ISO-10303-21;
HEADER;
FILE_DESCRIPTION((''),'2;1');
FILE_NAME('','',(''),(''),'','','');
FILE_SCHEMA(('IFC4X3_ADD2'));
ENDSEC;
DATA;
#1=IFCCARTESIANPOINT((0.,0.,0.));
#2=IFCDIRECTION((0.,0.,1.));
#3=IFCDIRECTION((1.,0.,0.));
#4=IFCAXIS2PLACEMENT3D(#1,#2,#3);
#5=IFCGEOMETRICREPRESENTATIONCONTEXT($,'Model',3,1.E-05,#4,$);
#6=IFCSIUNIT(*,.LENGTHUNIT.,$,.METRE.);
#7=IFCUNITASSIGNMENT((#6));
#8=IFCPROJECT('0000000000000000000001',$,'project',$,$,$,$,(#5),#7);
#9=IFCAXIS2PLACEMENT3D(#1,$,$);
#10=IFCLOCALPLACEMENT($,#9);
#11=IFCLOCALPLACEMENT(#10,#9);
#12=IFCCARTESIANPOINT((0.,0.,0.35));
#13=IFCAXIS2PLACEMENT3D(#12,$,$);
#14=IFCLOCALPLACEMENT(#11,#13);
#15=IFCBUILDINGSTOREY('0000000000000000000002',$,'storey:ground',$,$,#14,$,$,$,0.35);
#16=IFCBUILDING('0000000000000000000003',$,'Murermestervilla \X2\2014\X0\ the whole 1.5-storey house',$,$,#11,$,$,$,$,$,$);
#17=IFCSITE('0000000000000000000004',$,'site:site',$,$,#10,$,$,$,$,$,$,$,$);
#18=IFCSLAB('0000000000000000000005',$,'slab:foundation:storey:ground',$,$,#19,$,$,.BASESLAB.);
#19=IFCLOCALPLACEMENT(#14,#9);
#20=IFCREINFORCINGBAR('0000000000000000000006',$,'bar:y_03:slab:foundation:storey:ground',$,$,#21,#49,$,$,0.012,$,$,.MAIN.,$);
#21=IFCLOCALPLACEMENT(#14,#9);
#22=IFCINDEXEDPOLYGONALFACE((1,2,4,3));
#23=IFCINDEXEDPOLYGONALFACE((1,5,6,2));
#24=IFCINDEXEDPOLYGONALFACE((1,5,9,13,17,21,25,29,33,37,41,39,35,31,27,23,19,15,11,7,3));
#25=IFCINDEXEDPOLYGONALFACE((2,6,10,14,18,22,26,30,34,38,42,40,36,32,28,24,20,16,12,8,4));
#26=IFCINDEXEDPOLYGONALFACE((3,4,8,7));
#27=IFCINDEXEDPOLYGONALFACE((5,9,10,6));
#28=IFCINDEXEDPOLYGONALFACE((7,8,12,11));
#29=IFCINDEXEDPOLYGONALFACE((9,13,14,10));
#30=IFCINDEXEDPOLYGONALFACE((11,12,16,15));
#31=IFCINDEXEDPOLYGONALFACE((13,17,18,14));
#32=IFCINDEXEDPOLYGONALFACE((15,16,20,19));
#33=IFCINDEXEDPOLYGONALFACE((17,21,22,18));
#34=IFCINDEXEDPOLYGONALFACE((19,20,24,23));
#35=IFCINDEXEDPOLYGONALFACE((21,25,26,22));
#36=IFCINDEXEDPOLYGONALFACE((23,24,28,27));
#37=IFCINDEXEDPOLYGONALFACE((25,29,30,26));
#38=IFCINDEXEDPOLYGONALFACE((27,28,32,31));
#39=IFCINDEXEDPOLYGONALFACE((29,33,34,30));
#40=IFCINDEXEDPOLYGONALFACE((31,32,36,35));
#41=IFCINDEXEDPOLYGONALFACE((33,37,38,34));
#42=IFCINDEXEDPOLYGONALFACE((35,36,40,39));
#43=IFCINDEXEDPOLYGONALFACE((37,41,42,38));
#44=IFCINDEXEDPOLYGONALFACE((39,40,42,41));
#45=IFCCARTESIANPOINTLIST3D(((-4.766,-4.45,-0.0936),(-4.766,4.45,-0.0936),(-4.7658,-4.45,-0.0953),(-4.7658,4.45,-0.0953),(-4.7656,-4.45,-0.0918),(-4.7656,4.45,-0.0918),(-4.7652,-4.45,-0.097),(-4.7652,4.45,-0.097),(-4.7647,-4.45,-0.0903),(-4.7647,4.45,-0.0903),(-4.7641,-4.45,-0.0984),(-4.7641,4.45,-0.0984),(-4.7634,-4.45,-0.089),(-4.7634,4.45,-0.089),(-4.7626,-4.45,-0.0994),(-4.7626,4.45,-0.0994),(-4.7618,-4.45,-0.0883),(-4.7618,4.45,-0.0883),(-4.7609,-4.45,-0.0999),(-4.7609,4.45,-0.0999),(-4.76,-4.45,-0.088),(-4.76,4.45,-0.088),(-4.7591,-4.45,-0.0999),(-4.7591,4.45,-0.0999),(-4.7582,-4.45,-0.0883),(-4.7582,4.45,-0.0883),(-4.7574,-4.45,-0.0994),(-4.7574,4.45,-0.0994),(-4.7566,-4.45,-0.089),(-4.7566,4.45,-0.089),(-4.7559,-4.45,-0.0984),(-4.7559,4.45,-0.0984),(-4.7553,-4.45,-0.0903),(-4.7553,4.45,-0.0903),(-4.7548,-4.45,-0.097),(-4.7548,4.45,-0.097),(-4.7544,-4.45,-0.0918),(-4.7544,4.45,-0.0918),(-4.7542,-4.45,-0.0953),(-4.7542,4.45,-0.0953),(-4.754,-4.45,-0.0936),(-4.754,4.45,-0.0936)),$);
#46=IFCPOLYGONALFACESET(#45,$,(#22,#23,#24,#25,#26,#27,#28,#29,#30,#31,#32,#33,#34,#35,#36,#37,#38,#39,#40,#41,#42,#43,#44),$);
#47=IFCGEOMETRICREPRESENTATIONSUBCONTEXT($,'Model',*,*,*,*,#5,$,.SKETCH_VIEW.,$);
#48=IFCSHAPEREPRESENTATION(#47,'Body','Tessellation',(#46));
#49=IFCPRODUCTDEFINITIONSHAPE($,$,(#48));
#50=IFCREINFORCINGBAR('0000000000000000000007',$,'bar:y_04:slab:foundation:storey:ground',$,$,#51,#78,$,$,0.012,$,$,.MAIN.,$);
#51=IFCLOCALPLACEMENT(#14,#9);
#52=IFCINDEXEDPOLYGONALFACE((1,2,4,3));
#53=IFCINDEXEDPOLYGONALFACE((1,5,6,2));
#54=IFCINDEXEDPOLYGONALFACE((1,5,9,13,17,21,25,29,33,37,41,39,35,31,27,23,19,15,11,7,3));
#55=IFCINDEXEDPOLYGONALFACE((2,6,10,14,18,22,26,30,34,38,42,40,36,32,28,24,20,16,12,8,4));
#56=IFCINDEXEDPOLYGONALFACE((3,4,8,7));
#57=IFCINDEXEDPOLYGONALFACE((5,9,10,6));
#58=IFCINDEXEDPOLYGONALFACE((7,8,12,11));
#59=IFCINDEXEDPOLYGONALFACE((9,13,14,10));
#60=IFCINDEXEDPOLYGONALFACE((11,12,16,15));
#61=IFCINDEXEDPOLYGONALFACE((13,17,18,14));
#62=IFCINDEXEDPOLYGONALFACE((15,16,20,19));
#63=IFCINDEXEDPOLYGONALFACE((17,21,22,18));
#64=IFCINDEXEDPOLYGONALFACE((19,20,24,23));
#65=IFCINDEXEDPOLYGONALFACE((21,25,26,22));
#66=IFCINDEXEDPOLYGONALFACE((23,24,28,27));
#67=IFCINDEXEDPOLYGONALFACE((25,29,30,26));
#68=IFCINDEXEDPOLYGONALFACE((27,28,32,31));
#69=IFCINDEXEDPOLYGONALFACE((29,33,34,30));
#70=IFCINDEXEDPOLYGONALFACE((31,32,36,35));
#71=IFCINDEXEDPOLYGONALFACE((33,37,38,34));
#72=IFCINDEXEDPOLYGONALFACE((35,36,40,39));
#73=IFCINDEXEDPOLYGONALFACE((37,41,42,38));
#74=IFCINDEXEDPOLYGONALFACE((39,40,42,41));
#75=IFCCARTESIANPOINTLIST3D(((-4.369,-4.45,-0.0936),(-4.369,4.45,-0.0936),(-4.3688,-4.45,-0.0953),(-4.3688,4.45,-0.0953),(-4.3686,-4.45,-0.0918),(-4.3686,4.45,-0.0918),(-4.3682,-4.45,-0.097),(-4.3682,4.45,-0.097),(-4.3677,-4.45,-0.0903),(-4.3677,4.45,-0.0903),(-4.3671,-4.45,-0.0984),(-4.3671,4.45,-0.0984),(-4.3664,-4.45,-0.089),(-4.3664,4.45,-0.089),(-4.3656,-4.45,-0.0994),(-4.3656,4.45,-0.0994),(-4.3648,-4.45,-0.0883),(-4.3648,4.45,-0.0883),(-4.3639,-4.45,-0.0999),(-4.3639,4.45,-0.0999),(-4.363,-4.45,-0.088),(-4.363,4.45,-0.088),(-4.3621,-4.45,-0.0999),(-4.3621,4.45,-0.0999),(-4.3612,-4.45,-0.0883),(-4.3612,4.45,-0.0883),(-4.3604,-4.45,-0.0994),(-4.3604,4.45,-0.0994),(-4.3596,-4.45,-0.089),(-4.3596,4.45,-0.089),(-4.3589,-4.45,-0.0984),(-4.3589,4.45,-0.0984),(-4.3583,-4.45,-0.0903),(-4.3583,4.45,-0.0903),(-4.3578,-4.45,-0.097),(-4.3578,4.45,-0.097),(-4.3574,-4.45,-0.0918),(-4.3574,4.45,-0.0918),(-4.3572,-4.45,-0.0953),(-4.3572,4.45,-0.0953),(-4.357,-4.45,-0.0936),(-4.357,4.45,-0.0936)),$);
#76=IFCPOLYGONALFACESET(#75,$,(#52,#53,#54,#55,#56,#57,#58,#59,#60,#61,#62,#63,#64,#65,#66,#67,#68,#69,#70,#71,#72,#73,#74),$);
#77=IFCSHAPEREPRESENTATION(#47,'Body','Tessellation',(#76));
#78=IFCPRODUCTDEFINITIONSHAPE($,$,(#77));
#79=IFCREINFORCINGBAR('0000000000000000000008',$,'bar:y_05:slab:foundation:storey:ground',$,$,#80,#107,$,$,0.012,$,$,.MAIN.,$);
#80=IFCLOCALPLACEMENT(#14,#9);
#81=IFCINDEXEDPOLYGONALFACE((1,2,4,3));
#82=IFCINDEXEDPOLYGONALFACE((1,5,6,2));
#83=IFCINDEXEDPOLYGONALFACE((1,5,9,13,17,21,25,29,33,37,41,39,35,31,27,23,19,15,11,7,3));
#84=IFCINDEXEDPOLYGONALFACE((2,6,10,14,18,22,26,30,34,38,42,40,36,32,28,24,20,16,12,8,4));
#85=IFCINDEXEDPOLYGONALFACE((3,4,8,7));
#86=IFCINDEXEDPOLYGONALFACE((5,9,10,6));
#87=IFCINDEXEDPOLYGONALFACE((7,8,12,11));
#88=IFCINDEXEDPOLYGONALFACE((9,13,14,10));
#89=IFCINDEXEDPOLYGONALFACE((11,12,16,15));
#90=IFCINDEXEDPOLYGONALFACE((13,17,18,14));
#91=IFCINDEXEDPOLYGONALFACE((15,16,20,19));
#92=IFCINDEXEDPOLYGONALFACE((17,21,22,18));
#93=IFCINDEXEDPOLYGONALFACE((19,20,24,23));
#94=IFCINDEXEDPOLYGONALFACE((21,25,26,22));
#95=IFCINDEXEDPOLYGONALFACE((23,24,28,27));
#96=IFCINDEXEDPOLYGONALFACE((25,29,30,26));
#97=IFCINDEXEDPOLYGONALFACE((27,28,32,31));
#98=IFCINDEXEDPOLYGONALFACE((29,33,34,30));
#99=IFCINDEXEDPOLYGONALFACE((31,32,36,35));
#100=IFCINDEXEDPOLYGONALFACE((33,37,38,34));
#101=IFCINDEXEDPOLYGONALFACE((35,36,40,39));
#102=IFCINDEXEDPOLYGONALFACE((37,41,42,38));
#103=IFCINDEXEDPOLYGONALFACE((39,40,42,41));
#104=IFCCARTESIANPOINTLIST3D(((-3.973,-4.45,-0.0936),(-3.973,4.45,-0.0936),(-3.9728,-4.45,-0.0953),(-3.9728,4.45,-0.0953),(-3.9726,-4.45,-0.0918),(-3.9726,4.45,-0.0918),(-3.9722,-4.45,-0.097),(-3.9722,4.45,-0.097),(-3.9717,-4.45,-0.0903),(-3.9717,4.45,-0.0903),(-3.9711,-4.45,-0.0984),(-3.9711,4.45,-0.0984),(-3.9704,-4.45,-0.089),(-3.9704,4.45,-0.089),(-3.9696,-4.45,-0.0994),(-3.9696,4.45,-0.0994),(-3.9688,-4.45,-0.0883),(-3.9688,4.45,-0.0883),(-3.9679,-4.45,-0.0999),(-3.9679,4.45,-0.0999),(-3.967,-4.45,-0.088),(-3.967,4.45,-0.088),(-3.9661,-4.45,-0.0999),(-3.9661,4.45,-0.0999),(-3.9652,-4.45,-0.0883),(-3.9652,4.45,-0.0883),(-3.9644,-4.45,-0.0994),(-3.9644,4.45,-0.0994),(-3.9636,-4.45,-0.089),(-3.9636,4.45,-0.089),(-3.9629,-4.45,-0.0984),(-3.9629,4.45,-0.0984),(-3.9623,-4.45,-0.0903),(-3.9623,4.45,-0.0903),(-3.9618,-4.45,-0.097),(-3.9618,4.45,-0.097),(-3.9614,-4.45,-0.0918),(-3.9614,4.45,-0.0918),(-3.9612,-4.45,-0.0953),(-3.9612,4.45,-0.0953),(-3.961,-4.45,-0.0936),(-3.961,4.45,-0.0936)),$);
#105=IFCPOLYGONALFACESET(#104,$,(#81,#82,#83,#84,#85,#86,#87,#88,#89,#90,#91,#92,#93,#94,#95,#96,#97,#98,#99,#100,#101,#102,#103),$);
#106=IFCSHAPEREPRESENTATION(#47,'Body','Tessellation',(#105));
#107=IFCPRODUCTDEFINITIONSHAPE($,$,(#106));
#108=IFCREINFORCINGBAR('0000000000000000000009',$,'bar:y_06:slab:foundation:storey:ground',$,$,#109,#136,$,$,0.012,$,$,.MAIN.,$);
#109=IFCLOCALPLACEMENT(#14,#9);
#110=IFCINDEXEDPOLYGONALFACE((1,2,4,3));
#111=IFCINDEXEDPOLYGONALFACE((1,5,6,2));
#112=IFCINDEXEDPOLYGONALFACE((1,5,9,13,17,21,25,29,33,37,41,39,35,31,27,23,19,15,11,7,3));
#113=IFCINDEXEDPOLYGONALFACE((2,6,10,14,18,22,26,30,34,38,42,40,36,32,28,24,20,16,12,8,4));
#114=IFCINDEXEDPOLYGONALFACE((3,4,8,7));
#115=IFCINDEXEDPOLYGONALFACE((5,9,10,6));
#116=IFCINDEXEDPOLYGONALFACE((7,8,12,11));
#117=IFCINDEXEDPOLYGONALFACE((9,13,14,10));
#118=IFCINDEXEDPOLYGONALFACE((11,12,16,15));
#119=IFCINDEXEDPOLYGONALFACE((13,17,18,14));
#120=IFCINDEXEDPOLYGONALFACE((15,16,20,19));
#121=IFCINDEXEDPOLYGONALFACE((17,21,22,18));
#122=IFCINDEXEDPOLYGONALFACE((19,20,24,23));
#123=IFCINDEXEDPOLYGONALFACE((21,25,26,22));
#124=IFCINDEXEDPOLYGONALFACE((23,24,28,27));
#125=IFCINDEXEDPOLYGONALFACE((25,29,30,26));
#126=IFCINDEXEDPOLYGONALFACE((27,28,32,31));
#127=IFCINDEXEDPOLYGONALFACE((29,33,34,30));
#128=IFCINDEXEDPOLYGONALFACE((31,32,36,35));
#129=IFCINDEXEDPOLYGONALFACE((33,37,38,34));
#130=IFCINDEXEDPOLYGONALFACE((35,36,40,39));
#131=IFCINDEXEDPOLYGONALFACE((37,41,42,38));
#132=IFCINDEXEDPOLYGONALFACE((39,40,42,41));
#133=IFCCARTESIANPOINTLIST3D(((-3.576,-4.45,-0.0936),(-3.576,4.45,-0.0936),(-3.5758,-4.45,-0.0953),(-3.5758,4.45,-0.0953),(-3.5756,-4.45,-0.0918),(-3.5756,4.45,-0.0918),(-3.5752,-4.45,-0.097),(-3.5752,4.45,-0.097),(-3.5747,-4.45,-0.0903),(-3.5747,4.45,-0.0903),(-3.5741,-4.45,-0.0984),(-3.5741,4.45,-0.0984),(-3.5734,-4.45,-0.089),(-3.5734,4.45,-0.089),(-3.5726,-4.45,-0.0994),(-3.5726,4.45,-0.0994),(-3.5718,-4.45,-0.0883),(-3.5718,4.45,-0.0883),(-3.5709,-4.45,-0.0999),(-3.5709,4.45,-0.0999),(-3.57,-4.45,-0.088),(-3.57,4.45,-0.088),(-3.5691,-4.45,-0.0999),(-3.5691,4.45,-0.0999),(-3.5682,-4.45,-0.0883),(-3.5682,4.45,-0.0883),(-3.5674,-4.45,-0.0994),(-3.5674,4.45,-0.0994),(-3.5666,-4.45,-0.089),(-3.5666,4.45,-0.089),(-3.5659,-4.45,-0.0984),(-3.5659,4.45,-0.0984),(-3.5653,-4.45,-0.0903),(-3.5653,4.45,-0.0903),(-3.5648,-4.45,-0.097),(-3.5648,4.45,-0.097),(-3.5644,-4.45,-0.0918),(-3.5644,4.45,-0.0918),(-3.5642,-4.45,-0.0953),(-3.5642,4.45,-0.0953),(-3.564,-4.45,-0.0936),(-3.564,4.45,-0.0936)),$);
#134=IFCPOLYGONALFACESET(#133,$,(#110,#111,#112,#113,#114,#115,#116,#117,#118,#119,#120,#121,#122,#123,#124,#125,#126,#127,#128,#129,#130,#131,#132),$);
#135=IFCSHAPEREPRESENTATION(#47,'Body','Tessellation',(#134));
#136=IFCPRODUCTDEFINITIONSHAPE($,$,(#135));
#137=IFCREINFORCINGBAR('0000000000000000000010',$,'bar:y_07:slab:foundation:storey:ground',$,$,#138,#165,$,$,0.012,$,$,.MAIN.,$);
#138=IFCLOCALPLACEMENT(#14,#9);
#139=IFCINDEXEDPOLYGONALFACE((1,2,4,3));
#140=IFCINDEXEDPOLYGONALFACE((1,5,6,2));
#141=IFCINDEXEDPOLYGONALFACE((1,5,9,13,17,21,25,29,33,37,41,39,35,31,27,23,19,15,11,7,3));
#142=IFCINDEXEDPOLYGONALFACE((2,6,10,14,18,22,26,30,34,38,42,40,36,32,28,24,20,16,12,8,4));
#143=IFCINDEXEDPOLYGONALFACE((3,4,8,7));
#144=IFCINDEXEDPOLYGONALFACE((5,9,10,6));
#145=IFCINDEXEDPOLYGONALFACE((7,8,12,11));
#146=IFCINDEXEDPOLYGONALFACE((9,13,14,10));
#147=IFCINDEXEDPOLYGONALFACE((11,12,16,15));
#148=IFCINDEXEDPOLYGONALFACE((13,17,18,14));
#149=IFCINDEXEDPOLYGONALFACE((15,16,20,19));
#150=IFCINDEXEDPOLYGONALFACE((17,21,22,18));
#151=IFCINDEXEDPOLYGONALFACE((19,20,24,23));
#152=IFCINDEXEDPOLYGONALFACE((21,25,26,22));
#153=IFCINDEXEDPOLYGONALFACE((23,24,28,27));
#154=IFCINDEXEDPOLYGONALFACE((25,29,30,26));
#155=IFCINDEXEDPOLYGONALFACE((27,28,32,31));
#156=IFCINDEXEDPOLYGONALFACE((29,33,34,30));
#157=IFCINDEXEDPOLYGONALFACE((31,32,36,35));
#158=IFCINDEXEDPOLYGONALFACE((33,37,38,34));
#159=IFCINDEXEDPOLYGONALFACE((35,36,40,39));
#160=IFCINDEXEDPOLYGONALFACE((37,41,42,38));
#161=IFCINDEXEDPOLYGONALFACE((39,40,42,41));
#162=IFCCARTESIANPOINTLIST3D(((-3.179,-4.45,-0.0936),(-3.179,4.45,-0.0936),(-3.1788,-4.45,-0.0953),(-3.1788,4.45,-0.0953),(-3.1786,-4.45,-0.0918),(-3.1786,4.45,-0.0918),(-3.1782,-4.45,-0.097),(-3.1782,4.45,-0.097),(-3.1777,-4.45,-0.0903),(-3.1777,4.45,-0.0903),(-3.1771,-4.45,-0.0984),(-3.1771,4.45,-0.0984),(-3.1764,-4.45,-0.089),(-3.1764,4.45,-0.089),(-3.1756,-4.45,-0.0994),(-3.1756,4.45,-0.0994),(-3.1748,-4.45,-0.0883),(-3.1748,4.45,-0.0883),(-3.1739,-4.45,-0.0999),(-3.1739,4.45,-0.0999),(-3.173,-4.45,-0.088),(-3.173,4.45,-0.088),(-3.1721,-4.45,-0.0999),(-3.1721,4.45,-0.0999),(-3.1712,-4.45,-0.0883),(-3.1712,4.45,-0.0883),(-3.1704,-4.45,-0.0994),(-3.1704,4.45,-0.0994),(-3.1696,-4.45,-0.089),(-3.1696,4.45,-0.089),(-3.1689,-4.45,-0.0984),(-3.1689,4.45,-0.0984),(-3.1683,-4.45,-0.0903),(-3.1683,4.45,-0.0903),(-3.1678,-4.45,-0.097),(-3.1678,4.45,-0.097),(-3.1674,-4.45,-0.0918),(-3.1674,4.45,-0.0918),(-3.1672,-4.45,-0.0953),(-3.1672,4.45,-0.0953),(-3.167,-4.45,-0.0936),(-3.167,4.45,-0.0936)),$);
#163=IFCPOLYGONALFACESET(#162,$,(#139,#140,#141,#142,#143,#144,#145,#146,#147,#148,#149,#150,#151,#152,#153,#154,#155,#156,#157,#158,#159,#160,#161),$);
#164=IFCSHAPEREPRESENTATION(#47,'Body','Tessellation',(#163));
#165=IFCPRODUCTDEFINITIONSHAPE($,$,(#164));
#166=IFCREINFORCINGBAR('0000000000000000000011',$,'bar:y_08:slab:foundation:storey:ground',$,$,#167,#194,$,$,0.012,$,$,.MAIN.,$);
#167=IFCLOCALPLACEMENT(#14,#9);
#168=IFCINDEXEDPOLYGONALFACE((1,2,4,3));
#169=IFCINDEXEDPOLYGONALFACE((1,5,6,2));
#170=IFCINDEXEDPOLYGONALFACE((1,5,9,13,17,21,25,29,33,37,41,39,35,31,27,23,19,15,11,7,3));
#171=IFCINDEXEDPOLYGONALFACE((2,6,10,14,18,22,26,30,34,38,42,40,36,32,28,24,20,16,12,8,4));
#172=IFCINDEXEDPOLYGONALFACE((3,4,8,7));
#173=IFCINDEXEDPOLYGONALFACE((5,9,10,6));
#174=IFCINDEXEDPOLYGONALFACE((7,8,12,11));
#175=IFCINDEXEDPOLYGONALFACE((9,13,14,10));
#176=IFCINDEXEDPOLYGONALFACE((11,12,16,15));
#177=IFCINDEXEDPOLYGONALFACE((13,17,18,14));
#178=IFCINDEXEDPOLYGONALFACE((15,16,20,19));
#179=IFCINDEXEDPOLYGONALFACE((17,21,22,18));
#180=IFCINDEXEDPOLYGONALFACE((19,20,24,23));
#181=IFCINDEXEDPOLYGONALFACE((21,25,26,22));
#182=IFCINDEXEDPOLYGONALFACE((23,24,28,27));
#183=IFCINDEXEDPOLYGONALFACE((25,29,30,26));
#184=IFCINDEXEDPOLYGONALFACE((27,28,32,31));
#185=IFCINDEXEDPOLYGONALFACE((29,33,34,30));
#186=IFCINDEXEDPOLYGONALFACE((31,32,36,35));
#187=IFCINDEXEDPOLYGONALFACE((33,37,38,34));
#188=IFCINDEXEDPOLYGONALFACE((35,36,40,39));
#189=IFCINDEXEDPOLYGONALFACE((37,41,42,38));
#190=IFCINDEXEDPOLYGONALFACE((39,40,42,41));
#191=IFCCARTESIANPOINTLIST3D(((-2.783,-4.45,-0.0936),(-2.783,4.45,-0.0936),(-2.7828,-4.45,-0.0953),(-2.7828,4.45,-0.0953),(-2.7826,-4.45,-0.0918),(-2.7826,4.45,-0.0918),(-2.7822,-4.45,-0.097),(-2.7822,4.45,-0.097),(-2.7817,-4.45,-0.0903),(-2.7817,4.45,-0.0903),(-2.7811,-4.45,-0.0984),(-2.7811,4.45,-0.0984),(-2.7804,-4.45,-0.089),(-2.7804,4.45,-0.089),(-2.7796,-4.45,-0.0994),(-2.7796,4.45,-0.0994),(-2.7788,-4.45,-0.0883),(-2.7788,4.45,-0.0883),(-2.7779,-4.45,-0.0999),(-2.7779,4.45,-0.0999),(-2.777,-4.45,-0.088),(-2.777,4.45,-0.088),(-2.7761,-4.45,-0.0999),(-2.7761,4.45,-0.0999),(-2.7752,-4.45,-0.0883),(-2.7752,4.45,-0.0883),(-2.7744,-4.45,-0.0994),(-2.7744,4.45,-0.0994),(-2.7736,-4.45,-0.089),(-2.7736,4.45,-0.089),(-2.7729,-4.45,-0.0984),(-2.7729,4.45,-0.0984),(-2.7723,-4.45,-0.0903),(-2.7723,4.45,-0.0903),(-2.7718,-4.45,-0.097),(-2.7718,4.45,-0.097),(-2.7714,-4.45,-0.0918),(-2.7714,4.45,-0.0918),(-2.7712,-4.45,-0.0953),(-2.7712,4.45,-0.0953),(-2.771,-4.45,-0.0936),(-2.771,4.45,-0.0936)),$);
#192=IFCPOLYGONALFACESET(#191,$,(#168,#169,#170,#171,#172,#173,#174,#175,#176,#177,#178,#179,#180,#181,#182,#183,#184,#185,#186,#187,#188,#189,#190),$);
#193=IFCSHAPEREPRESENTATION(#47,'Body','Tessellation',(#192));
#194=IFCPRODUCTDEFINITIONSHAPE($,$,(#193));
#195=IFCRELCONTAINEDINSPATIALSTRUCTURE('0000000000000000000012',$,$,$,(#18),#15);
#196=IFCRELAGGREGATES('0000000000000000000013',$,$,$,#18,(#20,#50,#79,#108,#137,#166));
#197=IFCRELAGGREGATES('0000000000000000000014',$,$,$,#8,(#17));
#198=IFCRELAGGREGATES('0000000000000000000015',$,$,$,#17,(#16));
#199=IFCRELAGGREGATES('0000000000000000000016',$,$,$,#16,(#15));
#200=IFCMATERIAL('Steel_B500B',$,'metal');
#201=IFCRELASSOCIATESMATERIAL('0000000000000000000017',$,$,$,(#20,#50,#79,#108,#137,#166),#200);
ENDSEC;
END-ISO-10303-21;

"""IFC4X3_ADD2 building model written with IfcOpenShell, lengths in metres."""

from ifc_helpers import new_model, entity, si_unit, frame, origin, origin_with_axes, place, context, subcontext, project, spatial, material, element, aggregate, save


model = new_model("IFC4X3_ADD2")

# Units and contexts
model_context = context("Model", 3, precision=1e-05, world=origin_with_axes())
sub_context = subcontext(model_context, None, "Model", "SKETCH_VIEW")
ifc_project = project(units=[si_unit("LENGTHUNIT", "METRE")], contexts=[model_context])

# Site, building, storey
placement = place(None, origin())
site = spatial("IfcSite", under=ifc_project, at=placement, Name="site:site")
building_placement = place(placement, origin())
building = spatial("IfcBuilding", under=site, at=building_placement, Name="Murermestervilla — the whole 1.5-storey house")
storey_placement = place(building_placement, frame((0.0, 0.0, 0.35)))
storey = spatial("IfcBuildingStorey", under=building, at=storey_placement, Name="storey:ground", Elevation=0.35)

# Slab, reinforcing bars
slab_placement = place(storey_placement, frame((0.0, 0.0, -0.35)))
slab = element("IfcSlab", 1, at=slab_placement, inside=storey, Name="slab:foundation:storey:ground", PredefinedType="BASESLAB")
ifc_material = material(Name="Steel_B500B", Category="metal")
reinforcing_bar_1 = element("IfcReinforcingBar", 2, at=placement, material=ifc_material, Name="bar:y_03:slab:foundation:storey:ground", NominalDiameter=0.012, PredefinedType="MAIN", context=sub_context, shape_type="AdvancedSweptSolid", body=[
    entity("IfcSweptDiskSolid", entity("IfcPolyline", [entity("IfcCartesianPoint", [-4.76, -4.45, 0.256]), entity("IfcCartesianPoint", [-4.76, 4.45, 0.256])]), 0.006),
])
reinforcing_bar_2 = element("IfcReinforcingBar", 3, at=placement, material=ifc_material, Name="bar:y_04:slab:foundation:storey:ground", NominalDiameter=0.012, PredefinedType="MAIN", context=sub_context, shape_type="AdvancedSweptSolid", body=[
    entity("IfcSweptDiskSolid", entity("IfcPolyline", [entity("IfcCartesianPoint", [-4.363, -4.45, 0.256]), entity("IfcCartesianPoint", [-4.363, 4.45, 0.256])]), 0.006),
])
reinforcing_bar_3 = element("IfcReinforcingBar", 4, at=placement, material=ifc_material, Name="bar:y_05:slab:foundation:storey:ground", NominalDiameter=0.012, PredefinedType="MAIN", context=sub_context, shape_type="AdvancedSweptSolid", body=[
    entity("IfcSweptDiskSolid", entity("IfcPolyline", [entity("IfcCartesianPoint", [-3.967, -4.45, 0.256]), entity("IfcCartesianPoint", [-3.967, 4.45, 0.256])]), 0.006),
])
reinforcing_bar_4 = element("IfcReinforcingBar", 5, at=placement, material=ifc_material, Name="bar:y_06:slab:foundation:storey:ground", NominalDiameter=0.012, PredefinedType="MAIN", context=sub_context, shape_type="AdvancedSweptSolid", body=[
    entity("IfcSweptDiskSolid", entity("IfcPolyline", [entity("IfcCartesianPoint", [-3.57, -4.45, 0.256]), entity("IfcCartesianPoint", [-3.57, 4.45, 0.256])]), 0.006),
])
reinforcing_bar_5 = element("IfcReinforcingBar", 6, at=placement, material=ifc_material, Name="bar:y_07:slab:foundation:storey:ground", NominalDiameter=0.012, PredefinedType="MAIN", context=sub_context, shape_type="AdvancedSweptSolid", body=[
    entity("IfcSweptDiskSolid", entity("IfcPolyline", [entity("IfcCartesianPoint", [-3.173, -4.45, 0.256]), entity("IfcCartesianPoint", [-3.173, 4.45, 0.256])]), 0.006),
])
reinforcing_bar_6 = element("IfcReinforcingBar", 7, at=placement, material=ifc_material, Name="bar:y_08:slab:foundation:storey:ground", NominalDiameter=0.012, PredefinedType="MAIN", context=sub_context, shape_type="AdvancedSweptSolid", body=[
    entity("IfcSweptDiskSolid", entity("IfcPolyline", [entity("IfcCartesianPoint", [-2.777, -4.45, 0.256]), entity("IfcCartesianPoint", [-2.777, 4.45, 0.256])]), 0.006),
])
aggregate(slab, [reinforcing_bar_1, reinforcing_bar_2, reinforcing_bar_3, reinforcing_bar_4, reinforcing_bar_5, reinforcing_bar_6])

save(model, "model.ifc")
